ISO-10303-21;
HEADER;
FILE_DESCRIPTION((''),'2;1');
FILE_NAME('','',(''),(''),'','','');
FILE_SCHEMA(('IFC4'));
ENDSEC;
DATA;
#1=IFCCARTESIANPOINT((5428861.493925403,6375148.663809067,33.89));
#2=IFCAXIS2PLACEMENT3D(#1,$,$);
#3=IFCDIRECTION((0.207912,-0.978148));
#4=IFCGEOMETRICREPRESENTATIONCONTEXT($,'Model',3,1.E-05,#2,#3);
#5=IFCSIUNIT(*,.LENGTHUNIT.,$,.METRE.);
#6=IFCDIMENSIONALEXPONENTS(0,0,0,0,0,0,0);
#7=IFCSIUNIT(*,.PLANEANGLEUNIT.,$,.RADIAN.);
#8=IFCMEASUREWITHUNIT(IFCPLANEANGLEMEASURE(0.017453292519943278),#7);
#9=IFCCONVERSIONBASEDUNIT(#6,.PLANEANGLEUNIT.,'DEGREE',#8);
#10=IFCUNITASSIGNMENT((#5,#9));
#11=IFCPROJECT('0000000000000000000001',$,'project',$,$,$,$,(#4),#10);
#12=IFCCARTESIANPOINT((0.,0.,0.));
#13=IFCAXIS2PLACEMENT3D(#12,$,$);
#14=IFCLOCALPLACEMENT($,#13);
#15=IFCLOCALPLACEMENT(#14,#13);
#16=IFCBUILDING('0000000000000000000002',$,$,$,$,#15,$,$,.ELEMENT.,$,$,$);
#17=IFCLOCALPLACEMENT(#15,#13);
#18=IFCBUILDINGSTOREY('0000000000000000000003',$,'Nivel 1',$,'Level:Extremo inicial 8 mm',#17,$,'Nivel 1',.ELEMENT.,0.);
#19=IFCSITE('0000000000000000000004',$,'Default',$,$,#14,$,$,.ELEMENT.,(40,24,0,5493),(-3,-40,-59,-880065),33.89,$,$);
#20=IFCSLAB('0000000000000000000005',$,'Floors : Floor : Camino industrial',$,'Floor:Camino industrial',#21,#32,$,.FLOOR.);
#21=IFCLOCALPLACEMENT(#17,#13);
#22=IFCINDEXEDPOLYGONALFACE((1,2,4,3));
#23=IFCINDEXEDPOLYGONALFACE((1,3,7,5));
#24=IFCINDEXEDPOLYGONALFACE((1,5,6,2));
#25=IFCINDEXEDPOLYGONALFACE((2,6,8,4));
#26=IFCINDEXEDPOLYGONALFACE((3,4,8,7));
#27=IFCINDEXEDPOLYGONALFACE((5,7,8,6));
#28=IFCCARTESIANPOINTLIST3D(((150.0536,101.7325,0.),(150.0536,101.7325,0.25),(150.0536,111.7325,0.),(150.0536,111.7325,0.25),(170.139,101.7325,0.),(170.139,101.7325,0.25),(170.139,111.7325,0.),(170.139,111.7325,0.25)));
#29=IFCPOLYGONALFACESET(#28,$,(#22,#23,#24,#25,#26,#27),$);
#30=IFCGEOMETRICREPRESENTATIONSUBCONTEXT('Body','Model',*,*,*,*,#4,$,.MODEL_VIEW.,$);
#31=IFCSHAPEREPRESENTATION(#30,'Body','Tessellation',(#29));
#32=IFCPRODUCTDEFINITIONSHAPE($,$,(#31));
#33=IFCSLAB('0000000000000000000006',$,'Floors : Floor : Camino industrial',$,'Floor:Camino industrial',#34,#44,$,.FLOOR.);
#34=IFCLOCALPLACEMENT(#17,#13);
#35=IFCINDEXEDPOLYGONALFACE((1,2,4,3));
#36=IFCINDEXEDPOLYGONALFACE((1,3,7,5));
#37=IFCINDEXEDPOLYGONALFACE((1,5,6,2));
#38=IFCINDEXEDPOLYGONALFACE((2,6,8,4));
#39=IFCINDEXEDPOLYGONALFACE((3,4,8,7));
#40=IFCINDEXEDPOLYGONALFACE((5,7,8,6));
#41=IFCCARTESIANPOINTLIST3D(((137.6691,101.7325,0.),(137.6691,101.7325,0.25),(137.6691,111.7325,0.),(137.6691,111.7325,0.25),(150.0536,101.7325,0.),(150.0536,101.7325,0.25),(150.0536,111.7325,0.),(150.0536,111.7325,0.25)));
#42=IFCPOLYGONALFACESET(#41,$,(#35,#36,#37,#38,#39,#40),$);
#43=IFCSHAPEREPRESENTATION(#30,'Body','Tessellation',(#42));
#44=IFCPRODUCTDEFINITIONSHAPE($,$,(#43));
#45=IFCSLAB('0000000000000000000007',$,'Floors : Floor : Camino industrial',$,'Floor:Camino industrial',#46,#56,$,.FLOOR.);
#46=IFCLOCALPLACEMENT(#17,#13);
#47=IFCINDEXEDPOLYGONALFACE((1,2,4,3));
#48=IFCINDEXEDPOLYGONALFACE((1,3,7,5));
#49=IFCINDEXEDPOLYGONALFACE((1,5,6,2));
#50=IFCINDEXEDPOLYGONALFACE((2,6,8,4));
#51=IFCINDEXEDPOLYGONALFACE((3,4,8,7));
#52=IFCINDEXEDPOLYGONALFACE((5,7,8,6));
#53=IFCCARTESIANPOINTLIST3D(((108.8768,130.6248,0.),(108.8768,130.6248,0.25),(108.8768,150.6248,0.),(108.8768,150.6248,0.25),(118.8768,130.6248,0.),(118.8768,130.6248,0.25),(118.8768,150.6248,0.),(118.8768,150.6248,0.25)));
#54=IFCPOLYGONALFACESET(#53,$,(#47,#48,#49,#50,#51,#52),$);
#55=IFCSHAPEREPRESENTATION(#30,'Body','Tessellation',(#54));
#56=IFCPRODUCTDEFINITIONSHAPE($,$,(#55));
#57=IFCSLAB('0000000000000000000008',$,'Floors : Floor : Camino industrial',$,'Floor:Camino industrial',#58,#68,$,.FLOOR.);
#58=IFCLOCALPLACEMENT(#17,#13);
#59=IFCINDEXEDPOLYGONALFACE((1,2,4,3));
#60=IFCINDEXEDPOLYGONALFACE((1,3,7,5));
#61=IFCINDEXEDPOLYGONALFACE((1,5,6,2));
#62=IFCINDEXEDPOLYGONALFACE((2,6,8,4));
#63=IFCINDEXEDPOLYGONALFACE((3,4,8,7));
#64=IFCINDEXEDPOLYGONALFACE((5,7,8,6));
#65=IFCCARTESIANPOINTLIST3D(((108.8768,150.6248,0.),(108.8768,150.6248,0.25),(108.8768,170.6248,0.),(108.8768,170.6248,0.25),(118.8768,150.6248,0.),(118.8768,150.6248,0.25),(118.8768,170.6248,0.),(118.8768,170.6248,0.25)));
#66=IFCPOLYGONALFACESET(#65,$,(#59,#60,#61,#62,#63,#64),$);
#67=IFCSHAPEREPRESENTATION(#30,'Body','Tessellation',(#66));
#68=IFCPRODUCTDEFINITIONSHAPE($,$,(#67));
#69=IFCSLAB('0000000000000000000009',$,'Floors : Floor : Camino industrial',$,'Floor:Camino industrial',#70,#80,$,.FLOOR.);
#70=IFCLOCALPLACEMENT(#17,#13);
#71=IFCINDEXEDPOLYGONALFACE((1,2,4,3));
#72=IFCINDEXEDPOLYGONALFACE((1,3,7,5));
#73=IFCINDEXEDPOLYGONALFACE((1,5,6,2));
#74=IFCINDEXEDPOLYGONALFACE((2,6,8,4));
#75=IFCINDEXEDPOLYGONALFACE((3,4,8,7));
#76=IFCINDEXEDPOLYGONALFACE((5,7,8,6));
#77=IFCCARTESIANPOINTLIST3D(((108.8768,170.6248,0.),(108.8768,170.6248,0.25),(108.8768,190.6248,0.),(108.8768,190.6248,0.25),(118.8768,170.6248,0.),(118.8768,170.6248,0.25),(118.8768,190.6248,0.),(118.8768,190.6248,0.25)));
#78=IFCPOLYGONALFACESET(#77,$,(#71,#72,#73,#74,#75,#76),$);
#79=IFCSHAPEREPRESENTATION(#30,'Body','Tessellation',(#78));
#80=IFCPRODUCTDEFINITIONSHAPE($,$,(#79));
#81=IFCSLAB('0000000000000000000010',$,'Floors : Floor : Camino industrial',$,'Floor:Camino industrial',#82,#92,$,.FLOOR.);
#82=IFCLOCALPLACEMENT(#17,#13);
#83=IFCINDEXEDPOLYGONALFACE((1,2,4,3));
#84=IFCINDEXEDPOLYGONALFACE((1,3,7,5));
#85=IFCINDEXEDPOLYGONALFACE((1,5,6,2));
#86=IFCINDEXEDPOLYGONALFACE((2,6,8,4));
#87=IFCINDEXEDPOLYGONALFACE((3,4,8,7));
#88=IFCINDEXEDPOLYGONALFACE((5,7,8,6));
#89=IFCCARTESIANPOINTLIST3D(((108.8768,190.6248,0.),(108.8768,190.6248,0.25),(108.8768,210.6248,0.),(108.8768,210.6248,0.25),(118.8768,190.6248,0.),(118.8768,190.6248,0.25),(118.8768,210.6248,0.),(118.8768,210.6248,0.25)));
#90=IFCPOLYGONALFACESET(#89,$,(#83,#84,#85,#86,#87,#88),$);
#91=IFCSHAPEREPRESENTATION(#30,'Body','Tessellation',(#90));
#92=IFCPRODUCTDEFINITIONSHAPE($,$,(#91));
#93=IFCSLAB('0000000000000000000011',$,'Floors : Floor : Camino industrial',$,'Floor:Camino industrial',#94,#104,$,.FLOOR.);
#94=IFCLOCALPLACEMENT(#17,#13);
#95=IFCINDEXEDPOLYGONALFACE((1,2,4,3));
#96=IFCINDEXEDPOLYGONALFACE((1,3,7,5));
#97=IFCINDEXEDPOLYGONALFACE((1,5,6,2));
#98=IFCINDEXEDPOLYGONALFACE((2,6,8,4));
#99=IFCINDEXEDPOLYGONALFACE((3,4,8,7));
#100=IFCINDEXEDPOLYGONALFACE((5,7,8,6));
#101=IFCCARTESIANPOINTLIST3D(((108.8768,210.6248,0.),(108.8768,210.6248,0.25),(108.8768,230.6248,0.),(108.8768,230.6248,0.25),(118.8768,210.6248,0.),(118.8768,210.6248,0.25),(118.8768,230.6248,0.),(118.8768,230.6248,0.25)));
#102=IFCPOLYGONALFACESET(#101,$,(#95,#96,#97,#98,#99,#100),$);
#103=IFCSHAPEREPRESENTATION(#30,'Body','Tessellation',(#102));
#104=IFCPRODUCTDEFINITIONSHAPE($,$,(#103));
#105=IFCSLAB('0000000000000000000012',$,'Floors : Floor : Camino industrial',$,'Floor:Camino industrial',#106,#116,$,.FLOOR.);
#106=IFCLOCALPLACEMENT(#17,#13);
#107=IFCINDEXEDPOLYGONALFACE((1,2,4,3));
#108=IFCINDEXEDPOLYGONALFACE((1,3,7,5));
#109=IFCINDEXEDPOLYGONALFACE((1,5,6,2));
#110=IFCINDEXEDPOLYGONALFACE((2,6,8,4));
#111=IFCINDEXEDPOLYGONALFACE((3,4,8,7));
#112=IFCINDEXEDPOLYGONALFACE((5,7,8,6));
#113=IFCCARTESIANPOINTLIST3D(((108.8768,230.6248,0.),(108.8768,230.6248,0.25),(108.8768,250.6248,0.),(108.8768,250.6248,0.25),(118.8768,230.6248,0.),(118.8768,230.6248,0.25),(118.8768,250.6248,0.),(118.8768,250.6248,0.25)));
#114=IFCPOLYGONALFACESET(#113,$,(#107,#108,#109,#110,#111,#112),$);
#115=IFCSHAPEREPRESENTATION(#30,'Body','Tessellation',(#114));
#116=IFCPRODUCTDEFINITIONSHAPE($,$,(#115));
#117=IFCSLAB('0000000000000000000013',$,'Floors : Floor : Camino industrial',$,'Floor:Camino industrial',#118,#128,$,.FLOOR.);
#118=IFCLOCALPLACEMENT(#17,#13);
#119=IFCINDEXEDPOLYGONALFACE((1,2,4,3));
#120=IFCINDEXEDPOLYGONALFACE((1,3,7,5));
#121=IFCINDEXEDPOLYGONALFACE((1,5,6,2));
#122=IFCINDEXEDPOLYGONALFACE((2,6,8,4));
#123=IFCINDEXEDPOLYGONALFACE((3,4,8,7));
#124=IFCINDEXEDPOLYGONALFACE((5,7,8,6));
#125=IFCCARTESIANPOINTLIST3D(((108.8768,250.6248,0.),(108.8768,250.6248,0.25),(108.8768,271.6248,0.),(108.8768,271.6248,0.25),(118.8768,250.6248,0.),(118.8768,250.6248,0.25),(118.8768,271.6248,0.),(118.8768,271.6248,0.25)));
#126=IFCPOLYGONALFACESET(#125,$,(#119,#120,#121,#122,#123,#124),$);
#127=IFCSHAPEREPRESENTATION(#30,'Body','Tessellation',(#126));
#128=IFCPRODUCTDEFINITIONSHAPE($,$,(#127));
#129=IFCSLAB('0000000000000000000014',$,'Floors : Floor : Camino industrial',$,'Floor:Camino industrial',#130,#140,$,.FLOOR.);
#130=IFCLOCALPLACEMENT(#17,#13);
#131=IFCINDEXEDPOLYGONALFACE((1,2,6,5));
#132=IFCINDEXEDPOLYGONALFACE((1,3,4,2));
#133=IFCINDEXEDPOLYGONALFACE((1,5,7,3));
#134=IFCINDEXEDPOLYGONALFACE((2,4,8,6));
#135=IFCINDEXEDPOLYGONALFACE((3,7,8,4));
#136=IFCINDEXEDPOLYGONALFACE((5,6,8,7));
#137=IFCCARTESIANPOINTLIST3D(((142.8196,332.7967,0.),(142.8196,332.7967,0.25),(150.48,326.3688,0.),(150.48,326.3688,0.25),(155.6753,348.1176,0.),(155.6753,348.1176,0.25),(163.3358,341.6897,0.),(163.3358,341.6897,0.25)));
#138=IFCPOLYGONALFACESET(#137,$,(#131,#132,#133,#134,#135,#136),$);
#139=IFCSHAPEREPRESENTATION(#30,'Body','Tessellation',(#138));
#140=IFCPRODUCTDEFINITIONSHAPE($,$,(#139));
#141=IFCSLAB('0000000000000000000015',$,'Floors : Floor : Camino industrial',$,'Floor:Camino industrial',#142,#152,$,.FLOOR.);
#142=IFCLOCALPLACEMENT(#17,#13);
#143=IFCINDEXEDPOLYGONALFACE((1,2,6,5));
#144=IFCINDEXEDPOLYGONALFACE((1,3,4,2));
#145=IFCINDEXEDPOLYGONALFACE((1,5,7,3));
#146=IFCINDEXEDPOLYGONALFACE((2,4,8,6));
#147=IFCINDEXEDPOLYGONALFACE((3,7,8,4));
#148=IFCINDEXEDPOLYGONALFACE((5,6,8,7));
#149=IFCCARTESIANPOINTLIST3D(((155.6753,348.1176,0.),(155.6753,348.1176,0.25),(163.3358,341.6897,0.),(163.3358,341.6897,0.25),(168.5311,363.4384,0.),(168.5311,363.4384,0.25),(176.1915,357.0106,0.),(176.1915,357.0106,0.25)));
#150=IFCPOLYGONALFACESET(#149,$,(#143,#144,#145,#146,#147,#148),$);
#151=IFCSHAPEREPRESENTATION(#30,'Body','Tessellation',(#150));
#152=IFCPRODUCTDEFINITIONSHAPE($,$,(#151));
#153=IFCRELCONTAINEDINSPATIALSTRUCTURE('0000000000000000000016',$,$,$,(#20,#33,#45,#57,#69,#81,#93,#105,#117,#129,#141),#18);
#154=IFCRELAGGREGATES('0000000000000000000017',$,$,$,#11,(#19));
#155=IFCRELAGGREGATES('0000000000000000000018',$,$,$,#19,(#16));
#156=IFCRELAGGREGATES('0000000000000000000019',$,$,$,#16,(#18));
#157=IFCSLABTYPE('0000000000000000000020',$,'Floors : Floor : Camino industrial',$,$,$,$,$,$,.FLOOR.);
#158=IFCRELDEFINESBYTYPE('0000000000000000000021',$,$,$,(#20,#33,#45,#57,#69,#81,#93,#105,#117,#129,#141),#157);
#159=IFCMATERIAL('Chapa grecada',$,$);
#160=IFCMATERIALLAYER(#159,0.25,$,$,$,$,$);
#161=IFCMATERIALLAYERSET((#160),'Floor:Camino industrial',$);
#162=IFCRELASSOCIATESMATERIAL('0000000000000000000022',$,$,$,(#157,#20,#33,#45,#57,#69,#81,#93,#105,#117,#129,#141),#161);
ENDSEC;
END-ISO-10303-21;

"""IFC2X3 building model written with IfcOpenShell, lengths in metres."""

from ifc_helpers import new_model, entity, si_unit, converted_unit, direction, frame, frame_2d, origin, origin_2d_with_axis, place, context, subcontext, project, spatial, rectangle, extrude, material, layer, layer_set, layer_usage, type_object, element, save


model = new_model("IFC2X3")

# Units and contexts
model_context = context("Model", 3, precision=1e-05, world=frame((5428861.493925403, 6375148.663809067, 33.89)), true_north=direction((0.207912, -0.978148)))
body_context = subcontext(model_context, "Body", "Model", "MODEL_VIEW")
ifc_project = project(units=[si_unit("LENGTHUNIT", "METRE"), converted_unit("PLANEANGLEUNIT", "DEGREE", entity("IfcPlaneAngleMeasure", 0.017453292519943278), si_unit("PLANEANGLEUNIT", "RADIAN"), dimensions=[0, 0, 0, 0, 0, 0, 0])], contexts=[model_context])

# Site, building, storey
site_placement = place(None, origin())
site = spatial("IfcSite", under=ifc_project, at=site_placement, Name="Default", CompositionType="ELEMENT", RefLatitude=(40, 24, 0, 5493), RefLongitude=(-3, -40, -59, -880065), RefElevation=33.89)
building_placement = place(site_placement, origin())
building = spatial("IfcBuilding", under=site, at=building_placement, CompositionType="ELEMENT")
storey_placement = place(building_placement, origin())
storey = spatial("IfcBuildingStorey", under=building, at=storey_placement, Name="Nivel 1", ObjectType="Level:Extremo inicial 8 mm", LongName="Nivel 1", CompositionType="ELEMENT", Elevation=0.0)

# Slabs
ifc_material = material(Name="Chapa grecada")
ifc_layer = layer(ifc_material, 0.25)
ifc_layer_set = layer_set([ifc_layer], Name="Floor:Camino industrial")
slab_type = type_object("IfcSlabType", Name="Floors : Floor : Camino industrial", PredefinedType="FLOOR", material=ifc_layer_set)
ifc_layer_usage_1 = layer_usage(ifc_layer_set, "AXIS3", "POSITIVE", 0.0)
slab_1_placement = place(storey_placement, origin())
element("IfcSlab", 1, at=slab_1_placement, inside=storey, type_object=slab_type, material=ifc_layer_usage_1, Name="Floors : Floor : Camino industrial", ObjectType="Floor:Camino industrial", PredefinedType="FLOOR", context=body_context, shape_type="SweptSolid", body=[
    extrude(rectangle(XDim=10.0, YDim=20.0854, at=frame_2d((0.0, 0.0), x_axis=(1.0, 0.0))), frame((160.0963, 106.7325, 0.25), z_axis=(0.0, 0.0, -1.0), x_axis=(0.0, 1.0, 0.0)), (0.0, 0.0, 1.0), 0.25),
])
ifc_layer_usage_2 = layer_usage(ifc_layer_set, "AXIS3", "POSITIVE", 0.0)
slab_2_placement = place(storey_placement, origin())
element("IfcSlab", 2, at=slab_2_placement, inside=storey, type_object=slab_type, material=ifc_layer_usage_2, Name="Floors : Floor : Camino industrial", ObjectType="Floor:Camino industrial", PredefinedType="FLOOR", context=body_context, shape_type="SweptSolid", body=[
    extrude(rectangle(XDim=10.0, YDim=12.3846, at=frame_2d((0.0, 0.0), x_axis=(1.0, 0.0))), frame((143.8613, 106.7325, 0.25), z_axis=(0.0, 0.0, -1.0), x_axis=(0.0, 1.0, 0.0)), (0.0, 0.0, 1.0), 0.25),
])
ifc_layer_usage_3 = layer_usage(ifc_layer_set, "AXIS3", "POSITIVE", 0.0)
slab_3_placement = place(storey_placement, origin())
element("IfcSlab", 3, at=slab_3_placement, inside=storey, type_object=slab_type, material=ifc_layer_usage_3, Name="Floors : Floor : Camino industrial", ObjectType="Floor:Camino industrial", PredefinedType="FLOOR", context=body_context, shape_type="SweptSolid", body=[
    extrude(rectangle(XDim=20.0, YDim=10.0, at=origin_2d_with_axis()), frame((113.8768, 140.6248, 0.25), z_axis=(0.0, 0.0, -1.0), x_axis=(0.0, 1.0, 0.0)), (0.0, 0.0, 1.0), 0.25),
])
ifc_layer_usage_4 = layer_usage(ifc_layer_set, "AXIS3", "POSITIVE", 0.0)
slab_4_placement = place(storey_placement, origin())
element("IfcSlab", 4, at=slab_4_placement, inside=storey, type_object=slab_type, material=ifc_layer_usage_4, Name="Floors : Floor : Camino industrial", ObjectType="Floor:Camino industrial", PredefinedType="FLOOR", context=body_context, shape_type="SweptSolid", body=[
    extrude(rectangle(XDim=20.0, YDim=10.0, at=frame_2d((0.0, 0.0), x_axis=(1.0, 0.0))), frame((113.8768, 160.6248, 0.25), z_axis=(0.0, 0.0, -1.0), x_axis=(0.0, 1.0, 0.0)), (0.0, 0.0, 1.0), 0.25),
])
ifc_layer_usage_5 = layer_usage(ifc_layer_set, "AXIS3", "POSITIVE", 0.0)
slab_5_placement = place(storey_placement, origin())
element("IfcSlab", 5, at=slab_5_placement, inside=storey, type_object=slab_type, material=ifc_layer_usage_5, Name="Floors : Floor : Camino industrial", ObjectType="Floor:Camino industrial", PredefinedType="FLOOR", context=body_context, shape_type="SweptSolid", body=[
    extrude(rectangle(XDim=20.0, YDim=10.0, at=origin_2d_with_axis()), frame((113.8768, 180.6248, 0.25), z_axis=(0.0, 0.0, -1.0), x_axis=(0.0, 1.0, 0.0)), (0.0, 0.0, 1.0), 0.25),
])
ifc_layer_usage_6 = layer_usage(ifc_layer_set, "AXIS3", "POSITIVE", 0.0)
slab_6_placement = place(storey_placement, origin())
element("IfcSlab", 6, at=slab_6_placement, inside=storey, type_object=slab_type, material=ifc_layer_usage_6, Name="Floors : Floor : Camino industrial", ObjectType="Floor:Camino industrial", PredefinedType="FLOOR", context=body_context, shape_type="SweptSolid", body=[
    extrude(rectangle(XDim=20.0, YDim=10.0, at=frame_2d((0.0, 0.0), x_axis=(1.0, 0.0))), frame((113.8768, 200.6248, 0.25), z_axis=(0.0, 0.0, -1.0), x_axis=(0.0, 1.0, 0.0)), (0.0, 0.0, 1.0), 0.25),
])
ifc_layer_usage_7 = layer_usage(ifc_layer_set, "AXIS3", "POSITIVE", 0.0)
slab_7_placement = place(storey_placement, origin())
element("IfcSlab", 7, at=slab_7_placement, inside=storey, type_object=slab_type, material=ifc_layer_usage_7, Name="Floors : Floor : Camino industrial", ObjectType="Floor:Camino industrial", PredefinedType="FLOOR", context=body_context, shape_type="SweptSolid", body=[
    extrude(rectangle(XDim=20.0, YDim=10.0, at=frame_2d((0.0, 0.0), x_axis=(1.0, 0.0))), frame((113.8768, 220.6248, 0.25), z_axis=(0.0, 0.0, -1.0), x_axis=(0.0, 1.0, 0.0)), (0.0, 0.0, 1.0), 0.25),
])
ifc_layer_usage_8 = layer_usage(ifc_layer_set, "AXIS3", "POSITIVE", 0.0)
slab_8_placement = place(storey_placement, origin())
element("IfcSlab", 8, at=slab_8_placement, inside=storey, type_object=slab_type, material=ifc_layer_usage_8, Name="Floors : Floor : Camino industrial", ObjectType="Floor:Camino industrial", PredefinedType="FLOOR", context=body_context, shape_type="SweptSolid", body=[
    extrude(rectangle(XDim=20.0, YDim=10.0, at=frame_2d((0.0, 0.0), x_axis=(1.0, 0.0))), frame((113.8768, 240.6248, 0.25), z_axis=(0.0, 0.0, -1.0), x_axis=(0.0, 1.0, 0.0)), (0.0, 0.0, 1.0), 0.25),
])
ifc_layer_usage_9 = layer_usage(ifc_layer_set, "AXIS3", "POSITIVE", 0.0)
slab_9_placement = place(storey_placement, origin())
element("IfcSlab", 9, at=slab_9_placement, inside=storey, type_object=slab_type, material=ifc_layer_usage_9, Name="Floors : Floor : Camino industrial", ObjectType="Floor:Camino industrial", PredefinedType="FLOOR", context=body_context, shape_type="SweptSolid", body=[
    extrude(rectangle(XDim=21.0, YDim=10.0, at=origin_2d_with_axis()), frame((113.8768, 261.1248, 0.25), z_axis=(0.0, 0.0, -1.0), x_axis=(0.0, 1.0, 0.0)), (0.0, 0.0, 1.0), 0.25),
])
ifc_layer_usage_10 = layer_usage(ifc_layer_set, "AXIS3", "POSITIVE", 0.0)
slab_10_placement = place(storey_placement, origin())
element("IfcSlab", 10, at=slab_10_placement, inside=storey, type_object=slab_type, material=ifc_layer_usage_10, Name="Floors : Floor : Camino industrial", ObjectType="Floor:Camino industrial", PredefinedType="FLOOR", context=body_context, shape_type="SweptSolid", body=[
    extrude(rectangle(XDim=20.0, YDim=10.0, at=frame_2d((0.0, 0.0), x_axis=(1.0, 0.0))), frame((153.0777, 337.2432, 0.25), z_axis=(0.0, 0.0, -1.0), x_axis=(-0.642788, -0.766044, 0.0)), (0.0, 0.0, 1.0), 0.25),
])
ifc_layer_usage_11 = layer_usage(ifc_layer_set, "AXIS3", "POSITIVE", 0.0)
slab_11_placement = place(storey_placement, origin())
element("IfcSlab", 11, at=slab_11_placement, inside=storey, type_object=slab_type, material=ifc_layer_usage_11, Name="Floors : Floor : Camino industrial", ObjectType="Floor:Camino industrial", PredefinedType="FLOOR", context=body_context, shape_type="SweptSolid", body=[
    extrude(rectangle(XDim=20.0, YDim=10.0, at=frame_2d((0.0, 0.0), x_axis=(1.0, 0.0))), frame((165.9334, 352.5641, 0.25), z_axis=(0.0, 0.0, -1.0), x_axis=(-0.642788, -0.766044, 0.0)), (0.0, 0.0, 1.0), 0.25),
])

save(model, "model.ifc")
